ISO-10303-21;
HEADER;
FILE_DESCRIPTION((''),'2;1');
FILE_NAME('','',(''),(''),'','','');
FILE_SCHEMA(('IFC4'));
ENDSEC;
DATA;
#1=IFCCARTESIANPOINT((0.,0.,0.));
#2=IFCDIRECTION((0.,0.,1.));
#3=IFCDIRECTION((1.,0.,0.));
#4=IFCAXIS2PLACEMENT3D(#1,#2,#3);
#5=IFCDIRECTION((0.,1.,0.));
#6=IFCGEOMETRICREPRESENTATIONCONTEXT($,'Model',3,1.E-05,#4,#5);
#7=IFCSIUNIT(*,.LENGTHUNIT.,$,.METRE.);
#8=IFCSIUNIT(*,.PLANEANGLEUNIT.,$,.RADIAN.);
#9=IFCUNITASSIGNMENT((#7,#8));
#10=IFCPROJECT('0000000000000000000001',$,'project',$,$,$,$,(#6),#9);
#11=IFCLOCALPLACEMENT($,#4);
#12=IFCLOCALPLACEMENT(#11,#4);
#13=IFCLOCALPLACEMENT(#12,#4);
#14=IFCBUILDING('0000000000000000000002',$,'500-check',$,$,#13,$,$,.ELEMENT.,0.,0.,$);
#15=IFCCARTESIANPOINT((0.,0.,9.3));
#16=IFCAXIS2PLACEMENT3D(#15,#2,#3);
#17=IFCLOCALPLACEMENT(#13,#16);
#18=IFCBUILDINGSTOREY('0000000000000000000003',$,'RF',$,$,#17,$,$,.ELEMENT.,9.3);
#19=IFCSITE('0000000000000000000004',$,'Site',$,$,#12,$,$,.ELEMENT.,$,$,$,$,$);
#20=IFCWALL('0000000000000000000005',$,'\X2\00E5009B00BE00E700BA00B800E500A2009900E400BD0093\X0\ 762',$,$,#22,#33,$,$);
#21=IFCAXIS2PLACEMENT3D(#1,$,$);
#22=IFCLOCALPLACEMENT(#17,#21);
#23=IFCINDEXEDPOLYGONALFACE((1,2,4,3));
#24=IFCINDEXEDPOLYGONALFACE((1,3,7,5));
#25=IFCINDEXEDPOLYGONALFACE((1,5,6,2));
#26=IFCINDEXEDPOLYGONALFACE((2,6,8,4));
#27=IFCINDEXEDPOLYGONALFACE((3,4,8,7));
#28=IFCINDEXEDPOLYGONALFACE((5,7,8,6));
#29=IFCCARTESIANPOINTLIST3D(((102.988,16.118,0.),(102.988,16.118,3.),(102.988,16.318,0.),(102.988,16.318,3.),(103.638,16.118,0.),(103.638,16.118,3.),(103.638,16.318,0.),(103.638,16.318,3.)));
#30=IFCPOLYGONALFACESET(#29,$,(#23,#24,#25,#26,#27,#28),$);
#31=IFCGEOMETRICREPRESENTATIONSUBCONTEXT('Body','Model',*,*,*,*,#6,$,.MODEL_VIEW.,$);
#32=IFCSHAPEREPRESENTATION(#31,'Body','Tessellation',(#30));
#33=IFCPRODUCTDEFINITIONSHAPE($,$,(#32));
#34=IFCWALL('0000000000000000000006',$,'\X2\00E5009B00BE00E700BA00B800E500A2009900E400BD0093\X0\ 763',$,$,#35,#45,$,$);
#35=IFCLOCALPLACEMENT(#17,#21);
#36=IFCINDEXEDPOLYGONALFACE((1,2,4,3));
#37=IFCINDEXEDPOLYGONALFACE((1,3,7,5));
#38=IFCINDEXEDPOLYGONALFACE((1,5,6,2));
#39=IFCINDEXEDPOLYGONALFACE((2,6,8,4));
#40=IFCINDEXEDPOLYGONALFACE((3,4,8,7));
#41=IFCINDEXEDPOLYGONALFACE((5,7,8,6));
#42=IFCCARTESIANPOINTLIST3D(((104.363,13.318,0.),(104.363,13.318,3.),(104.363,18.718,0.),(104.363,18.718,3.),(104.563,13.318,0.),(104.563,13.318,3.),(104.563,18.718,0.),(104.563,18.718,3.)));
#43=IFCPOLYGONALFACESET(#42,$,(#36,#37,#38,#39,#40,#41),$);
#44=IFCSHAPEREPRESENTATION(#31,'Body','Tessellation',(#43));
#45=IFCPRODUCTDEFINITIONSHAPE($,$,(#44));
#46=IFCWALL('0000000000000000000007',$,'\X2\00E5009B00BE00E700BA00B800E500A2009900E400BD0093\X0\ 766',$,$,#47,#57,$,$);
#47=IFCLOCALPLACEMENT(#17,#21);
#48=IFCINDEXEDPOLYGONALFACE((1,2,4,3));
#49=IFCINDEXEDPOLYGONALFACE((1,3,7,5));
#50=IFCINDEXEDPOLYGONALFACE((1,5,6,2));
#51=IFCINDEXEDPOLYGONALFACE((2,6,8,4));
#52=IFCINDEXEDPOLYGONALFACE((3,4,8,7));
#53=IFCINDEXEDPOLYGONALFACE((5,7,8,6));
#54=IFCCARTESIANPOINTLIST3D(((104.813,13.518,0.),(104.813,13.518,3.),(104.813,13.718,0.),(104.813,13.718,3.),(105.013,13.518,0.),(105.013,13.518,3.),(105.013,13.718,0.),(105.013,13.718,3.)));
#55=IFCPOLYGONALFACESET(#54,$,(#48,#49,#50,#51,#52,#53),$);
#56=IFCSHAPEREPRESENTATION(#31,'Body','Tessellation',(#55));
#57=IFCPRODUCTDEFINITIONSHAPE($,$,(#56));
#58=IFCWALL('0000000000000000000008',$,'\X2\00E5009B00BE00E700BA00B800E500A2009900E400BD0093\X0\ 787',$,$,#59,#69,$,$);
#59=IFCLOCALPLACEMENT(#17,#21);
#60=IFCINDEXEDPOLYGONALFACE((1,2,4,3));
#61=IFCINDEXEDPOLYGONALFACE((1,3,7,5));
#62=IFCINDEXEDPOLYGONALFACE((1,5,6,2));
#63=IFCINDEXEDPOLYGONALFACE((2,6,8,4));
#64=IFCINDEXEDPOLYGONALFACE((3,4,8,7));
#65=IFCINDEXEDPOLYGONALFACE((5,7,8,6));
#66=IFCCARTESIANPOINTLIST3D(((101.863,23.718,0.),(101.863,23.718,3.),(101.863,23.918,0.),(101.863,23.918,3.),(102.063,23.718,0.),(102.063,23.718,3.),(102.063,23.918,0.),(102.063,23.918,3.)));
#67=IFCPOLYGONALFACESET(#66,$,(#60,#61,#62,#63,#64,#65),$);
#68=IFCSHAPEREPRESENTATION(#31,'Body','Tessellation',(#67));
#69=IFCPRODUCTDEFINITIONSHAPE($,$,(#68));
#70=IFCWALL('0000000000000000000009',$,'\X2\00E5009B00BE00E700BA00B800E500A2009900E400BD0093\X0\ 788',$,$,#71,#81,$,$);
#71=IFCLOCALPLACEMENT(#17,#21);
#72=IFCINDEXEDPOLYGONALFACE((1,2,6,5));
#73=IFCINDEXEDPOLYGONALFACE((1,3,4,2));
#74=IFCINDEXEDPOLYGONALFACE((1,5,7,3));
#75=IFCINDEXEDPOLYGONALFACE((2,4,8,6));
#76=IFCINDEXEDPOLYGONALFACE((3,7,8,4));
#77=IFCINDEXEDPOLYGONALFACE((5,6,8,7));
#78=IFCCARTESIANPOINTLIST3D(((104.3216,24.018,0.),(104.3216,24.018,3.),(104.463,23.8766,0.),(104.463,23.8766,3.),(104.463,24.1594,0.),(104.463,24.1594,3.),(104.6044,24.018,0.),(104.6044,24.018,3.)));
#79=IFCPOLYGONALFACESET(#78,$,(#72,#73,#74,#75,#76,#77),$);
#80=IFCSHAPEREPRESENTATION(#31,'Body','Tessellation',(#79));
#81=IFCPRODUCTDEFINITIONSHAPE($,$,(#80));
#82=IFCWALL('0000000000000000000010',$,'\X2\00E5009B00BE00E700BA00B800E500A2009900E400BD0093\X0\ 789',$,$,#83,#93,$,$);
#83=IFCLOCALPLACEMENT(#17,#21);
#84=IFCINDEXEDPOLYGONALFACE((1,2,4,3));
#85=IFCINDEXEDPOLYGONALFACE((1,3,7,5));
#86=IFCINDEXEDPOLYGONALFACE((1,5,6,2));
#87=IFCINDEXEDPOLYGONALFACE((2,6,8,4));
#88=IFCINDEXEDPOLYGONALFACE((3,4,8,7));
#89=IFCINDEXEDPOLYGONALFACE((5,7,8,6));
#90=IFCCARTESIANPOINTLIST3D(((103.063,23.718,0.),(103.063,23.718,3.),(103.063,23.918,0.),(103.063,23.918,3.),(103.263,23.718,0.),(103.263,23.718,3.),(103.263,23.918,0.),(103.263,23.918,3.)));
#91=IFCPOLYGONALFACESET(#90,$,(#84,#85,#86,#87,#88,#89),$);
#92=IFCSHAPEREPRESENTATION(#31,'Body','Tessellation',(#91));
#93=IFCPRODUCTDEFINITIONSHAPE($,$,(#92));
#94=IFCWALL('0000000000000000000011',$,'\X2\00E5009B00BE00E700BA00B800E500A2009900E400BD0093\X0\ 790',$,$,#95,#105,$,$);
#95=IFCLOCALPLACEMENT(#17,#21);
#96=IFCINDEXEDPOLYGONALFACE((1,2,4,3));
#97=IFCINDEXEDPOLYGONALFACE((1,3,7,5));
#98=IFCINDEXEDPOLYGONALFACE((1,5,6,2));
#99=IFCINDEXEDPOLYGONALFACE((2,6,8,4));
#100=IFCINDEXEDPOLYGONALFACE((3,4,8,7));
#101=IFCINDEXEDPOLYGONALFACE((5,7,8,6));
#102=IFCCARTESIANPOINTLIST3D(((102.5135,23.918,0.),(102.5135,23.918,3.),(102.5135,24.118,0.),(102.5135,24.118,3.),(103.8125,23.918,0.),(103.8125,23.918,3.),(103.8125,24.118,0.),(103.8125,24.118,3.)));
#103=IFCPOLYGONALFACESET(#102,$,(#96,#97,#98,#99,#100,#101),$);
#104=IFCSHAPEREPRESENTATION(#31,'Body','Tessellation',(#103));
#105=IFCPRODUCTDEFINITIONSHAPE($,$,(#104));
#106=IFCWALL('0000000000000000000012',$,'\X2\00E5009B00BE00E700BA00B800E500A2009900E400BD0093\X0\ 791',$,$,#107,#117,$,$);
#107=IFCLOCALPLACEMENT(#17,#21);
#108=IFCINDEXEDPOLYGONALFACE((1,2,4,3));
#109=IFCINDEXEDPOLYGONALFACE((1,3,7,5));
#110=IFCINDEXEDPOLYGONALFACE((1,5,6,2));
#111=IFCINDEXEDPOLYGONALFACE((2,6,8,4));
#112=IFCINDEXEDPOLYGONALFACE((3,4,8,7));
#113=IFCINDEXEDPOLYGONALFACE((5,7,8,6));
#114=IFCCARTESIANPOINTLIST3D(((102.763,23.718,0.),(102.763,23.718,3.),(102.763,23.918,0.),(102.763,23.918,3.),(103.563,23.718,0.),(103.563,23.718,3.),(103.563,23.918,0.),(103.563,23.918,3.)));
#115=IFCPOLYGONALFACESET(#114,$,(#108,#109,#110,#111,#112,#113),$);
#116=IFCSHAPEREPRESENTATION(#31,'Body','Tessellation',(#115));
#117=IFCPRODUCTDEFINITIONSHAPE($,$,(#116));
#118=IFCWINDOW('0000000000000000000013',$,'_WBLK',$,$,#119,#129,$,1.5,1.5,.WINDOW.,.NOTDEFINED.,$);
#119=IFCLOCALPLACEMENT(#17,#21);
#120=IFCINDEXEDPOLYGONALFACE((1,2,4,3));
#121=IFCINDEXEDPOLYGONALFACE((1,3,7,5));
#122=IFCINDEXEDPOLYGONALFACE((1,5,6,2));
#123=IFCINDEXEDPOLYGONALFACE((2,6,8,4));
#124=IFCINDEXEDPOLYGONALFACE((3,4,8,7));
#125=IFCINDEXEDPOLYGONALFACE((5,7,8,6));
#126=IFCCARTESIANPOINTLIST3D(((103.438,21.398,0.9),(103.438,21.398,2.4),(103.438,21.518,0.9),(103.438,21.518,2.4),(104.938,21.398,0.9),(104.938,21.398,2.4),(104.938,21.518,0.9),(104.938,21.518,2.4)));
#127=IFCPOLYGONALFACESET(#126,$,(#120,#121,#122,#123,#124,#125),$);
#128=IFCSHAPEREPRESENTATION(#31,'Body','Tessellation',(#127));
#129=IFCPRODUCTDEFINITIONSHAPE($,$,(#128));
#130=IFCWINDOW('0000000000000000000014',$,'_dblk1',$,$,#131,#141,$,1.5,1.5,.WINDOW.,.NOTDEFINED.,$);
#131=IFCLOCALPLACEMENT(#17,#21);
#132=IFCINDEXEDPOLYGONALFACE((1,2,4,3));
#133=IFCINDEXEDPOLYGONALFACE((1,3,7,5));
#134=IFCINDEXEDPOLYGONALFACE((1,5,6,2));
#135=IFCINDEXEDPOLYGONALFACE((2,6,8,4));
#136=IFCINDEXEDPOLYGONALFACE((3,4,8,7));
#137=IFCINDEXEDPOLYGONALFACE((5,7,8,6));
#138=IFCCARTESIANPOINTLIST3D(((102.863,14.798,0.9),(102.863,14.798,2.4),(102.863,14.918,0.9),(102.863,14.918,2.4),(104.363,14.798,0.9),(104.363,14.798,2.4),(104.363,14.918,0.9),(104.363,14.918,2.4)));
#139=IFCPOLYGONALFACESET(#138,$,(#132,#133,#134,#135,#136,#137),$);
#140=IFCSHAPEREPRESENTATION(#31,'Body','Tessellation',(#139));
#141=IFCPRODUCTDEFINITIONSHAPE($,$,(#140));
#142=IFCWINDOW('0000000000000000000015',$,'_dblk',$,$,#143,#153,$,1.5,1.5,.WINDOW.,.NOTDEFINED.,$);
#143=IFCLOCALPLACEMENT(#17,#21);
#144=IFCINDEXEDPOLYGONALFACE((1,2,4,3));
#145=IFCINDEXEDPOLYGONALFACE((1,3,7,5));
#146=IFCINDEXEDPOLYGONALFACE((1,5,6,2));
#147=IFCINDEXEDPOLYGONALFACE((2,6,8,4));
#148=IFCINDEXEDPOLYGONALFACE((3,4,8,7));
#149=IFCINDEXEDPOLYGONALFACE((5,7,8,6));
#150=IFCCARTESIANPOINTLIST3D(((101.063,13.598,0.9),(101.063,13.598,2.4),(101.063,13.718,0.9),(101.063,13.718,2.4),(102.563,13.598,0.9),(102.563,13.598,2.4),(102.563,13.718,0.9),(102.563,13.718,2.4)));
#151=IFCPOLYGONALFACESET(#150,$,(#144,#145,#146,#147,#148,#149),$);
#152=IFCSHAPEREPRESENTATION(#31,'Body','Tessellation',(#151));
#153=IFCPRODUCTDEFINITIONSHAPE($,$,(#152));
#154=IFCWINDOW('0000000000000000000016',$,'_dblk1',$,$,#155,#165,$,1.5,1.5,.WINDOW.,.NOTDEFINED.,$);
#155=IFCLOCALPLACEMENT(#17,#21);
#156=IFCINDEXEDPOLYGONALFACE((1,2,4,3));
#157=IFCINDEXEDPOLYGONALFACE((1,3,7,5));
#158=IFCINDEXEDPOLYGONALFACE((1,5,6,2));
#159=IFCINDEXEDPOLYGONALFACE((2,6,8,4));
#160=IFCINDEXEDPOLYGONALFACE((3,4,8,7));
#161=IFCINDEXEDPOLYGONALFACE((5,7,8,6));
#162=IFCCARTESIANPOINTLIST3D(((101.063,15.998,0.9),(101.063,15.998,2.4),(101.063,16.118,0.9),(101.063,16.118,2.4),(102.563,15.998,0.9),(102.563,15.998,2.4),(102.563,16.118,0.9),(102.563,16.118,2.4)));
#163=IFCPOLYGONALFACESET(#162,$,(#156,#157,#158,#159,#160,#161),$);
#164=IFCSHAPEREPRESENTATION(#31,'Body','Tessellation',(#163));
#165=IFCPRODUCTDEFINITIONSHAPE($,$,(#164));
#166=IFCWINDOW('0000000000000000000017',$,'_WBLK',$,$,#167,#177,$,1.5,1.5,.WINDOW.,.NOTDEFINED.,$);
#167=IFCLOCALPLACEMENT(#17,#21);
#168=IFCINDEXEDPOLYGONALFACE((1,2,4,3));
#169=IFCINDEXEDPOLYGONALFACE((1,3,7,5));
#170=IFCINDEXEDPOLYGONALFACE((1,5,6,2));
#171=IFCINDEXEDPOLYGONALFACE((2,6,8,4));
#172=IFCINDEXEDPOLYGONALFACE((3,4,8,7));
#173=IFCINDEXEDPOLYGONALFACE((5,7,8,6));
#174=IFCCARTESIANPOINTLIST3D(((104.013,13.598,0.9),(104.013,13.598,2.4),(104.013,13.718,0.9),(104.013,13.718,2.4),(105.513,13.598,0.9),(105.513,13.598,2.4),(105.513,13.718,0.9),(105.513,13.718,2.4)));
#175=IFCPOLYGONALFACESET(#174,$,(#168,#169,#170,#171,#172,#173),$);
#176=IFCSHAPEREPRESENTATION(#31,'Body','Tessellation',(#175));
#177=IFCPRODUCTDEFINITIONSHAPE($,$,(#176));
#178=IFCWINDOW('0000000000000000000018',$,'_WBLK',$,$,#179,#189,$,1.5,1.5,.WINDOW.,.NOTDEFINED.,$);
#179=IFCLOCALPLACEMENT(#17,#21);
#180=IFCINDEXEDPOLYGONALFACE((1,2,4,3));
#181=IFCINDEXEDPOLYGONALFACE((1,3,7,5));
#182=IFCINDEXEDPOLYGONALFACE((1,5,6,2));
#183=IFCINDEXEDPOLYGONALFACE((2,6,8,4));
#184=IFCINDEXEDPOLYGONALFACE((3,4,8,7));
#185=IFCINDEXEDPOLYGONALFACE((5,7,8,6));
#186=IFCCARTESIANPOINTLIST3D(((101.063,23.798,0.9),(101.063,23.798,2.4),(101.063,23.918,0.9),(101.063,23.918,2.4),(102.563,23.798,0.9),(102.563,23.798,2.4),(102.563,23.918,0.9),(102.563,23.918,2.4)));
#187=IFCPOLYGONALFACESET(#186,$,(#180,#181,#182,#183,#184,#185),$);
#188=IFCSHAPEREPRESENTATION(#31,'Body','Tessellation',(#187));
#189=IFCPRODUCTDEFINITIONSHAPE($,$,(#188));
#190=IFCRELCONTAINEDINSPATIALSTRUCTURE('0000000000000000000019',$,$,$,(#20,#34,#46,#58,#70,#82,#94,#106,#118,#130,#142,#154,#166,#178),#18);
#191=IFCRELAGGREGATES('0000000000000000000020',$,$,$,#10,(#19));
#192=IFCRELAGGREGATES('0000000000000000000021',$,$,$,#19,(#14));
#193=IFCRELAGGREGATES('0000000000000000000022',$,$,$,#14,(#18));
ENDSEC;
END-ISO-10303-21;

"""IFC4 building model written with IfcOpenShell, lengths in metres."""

from ifc_helpers import new_model, si_unit, direction, frame, frame_2d, origin_with_axes, place, context, subcontext, project, spatial, rectangle, extrude, element, save


model = new_model("IFC4")

# Units and contexts
model_context = context("Model", 3, precision=1e-05, world=origin_with_axes(), true_north=direction((0.0, 1.0, 0.0)))
body_context = subcontext(model_context, "Body", "Model", "MODEL_VIEW")
ifc_project = project(units=[si_unit("LENGTHUNIT", "METRE"), si_unit("PLANEANGLEUNIT", "RADIAN")], contexts=[model_context])

# Site, building, storey
placement = place(None, origin_with_axes())
site_placement = place(placement, origin_with_axes())
site = spatial("IfcSite", under=ifc_project, at=site_placement, Name="Site", CompositionType="ELEMENT")
building_placement = place(site_placement, origin_with_axes())
building = spatial("IfcBuilding", under=site, at=building_placement, Name="500-check", CompositionType="ELEMENT", ElevationOfRefHeight=0.0, ElevationOfTerrain=0.0)
storey_placement = place(building_placement, frame((0.0, 0.0, 9.3), z_axis=(0.0, 0.0, 1.0), x_axis=(1.0, 0.0, 0.0)))
storey = spatial("IfcBuildingStorey", under=building, at=storey_placement, Name="RF", CompositionType="ELEMENT", Elevation=9.3)

# Walls
wall_1_placement = place(storey_placement, frame((103.313, 16.218, 0.0), z_axis=(0.0, 0.0, 1.0), x_axis=(1.0, 0.0, 0.0)))
element("IfcWall", 1, at=wall_1_placement, inside=storey, Name="å\u009b¾çº¸å¢\u0099ä½\u0093 762", context=body_context, shape_type="SweptSolid", body=[
    extrude(rectangle(XDim=0.65, YDim=0.2, at=frame_2d((0.0, 0.0), x_axis=(1.0, 0.0, 0.0))), frame((0.0, 0.0, 0.0), z_axis=(0.0, 0.0, 1.0)), (0.0, 0.0, 1.0), 3.0),
])
wall_2_placement = place(storey_placement, frame((104.463, 16.018, 0.0), z_axis=(0.0, 0.0, 1.0), x_axis=(0.0, 1.0, 0.0)))
element("IfcWall", 2, at=wall_2_placement, inside=storey, Name="å\u009b¾çº¸å¢\u0099ä½\u0093 763", context=body_context, shape_type="SweptSolid", body=[
    extrude(rectangle(XDim=5.4, YDim=0.2, at=frame_2d((0.0, 0.0), x_axis=(1.0, 0.0, 0.0))), frame((0.0, 0.0, 0.0), z_axis=(0.0, 0.0, 1.0)), (0.0, 0.0, 1.0), 3.0),
])
for number, where, z_axis, x_axis, name in (
    (3, (104.913, 13.618, 0.0), (0.0, 0.0, 1.0), (0.0, 1.0, 0.0), "å\u009b¾çº¸å¢\u0099ä½\u0093 766"),
    (4, (101.963, 23.818, 0.0), (0.0, 0.0, 1.0), (0.0, 1.0, 0.0), "å\u009b¾çº¸å¢\u0099ä½\u0093 787"),
    (5, (104.463, 24.018, 0.0), (0.0, 0.0, 1.0), (0.707107, -0.707107, 0.0), "å\u009b¾çº¸å¢\u0099ä½\u0093 788"),
    (6, (103.163, 23.818, 0.0), (0.0, 0.0, 1.0), (0.0, 1.0, 0.0), "å\u009b¾çº¸å¢\u0099ä½\u0093 789"),
):
    element("IfcWall", number, at=place(storey_placement, frame(where, z_axis=z_axis, x_axis=x_axis)), inside=storey, Name=name, context=body_context, shape_type="SweptSolid", body=[
        extrude(rectangle(XDim=0.2, YDim=0.2, at=frame_2d((0.0, 0.0), x_axis=(1.0, 0.0, 0.0))), frame((0.0, 0.0, 0.0), z_axis=(0.0, 0.0, 1.0)), (0.0, 0.0, 1.0), 3.0),
    ])
wall_3_placement = place(storey_placement, frame((103.163, 24.018, 0.0), z_axis=(0.0, 0.0, 1.0), x_axis=(1.0, 0.0, 0.0)))
element("IfcWall", 7, at=wall_3_placement, inside=storey, Name="å\u009b¾çº¸å¢\u0099ä½\u0093 790", context=body_context, shape_type="SweptSolid", body=[
    extrude(rectangle(XDim=1.299, YDim=0.2, at=frame_2d((0.0, 0.0), x_axis=(1.0, 0.0, 0.0))), frame((0.0, 0.0, 0.0), z_axis=(0.0, 0.0, 1.0)), (0.0, 0.0, 1.0), 3.0),
])
wall_4_placement = place(storey_placement, frame((103.163, 23.818, 0.0), z_axis=(0.0, 0.0, 1.0), x_axis=(1.0, 0.0, 0.0)))
element("IfcWall", 8, at=wall_4_placement, inside=storey, Name="å\u009b¾çº¸å¢\u0099ä½\u0093 791", context=body_context, shape_type="SweptSolid", body=[
    extrude(rectangle(XDim=0.8, YDim=0.2, at=frame_2d((0.0, 0.0), x_axis=(1.0, 0.0, 0.0))), frame((0.0, 0.0, 0.0), z_axis=(0.0, 0.0, 1.0)), (0.0, 0.0, 1.0), 3.0),
])

# Windows
for number, where, z_axis, x_axis, name in (
    (9, (104.188, 21.458, 0.9), (0.0, 0.0, 1.0), (1.0, 0.0, 0.0), "_WBLK"),
    (10, (103.613, 14.858, 0.9), (0.0, 0.0, 1.0), (1.0, 0.0, 0.0), "_dblk1"),
    (11, (101.813, 13.658, 0.9), (0.0, 0.0, 1.0), (1.0, 0.0, 0.0), "_dblk"),
    (12, (101.813, 16.058, 0.9), (0.0, 0.0, 1.0), (1.0, 0.0, 0.0), "_dblk1"),
    (13, (104.763, 13.658, 0.9), (0.0, 0.0, 1.0), (1.0, 0.0, 0.0), "_WBLK"),
    (14, (101.813, 23.858, 0.9), (0.0, 0.0, 1.0), (1.0, 0.0, 0.0), "_WBLK"),
):
    element("IfcWindow", number, at=place(storey_placement, frame(where, z_axis=z_axis, x_axis=x_axis)), inside=storey, Name=name, OverallHeight=1.5, OverallWidth=1.5, PartitioningType="NOTDEFINED", PredefinedType="WINDOW", context=body_context, shape_type="SweptSolid", body=[
        extrude(rectangle(XDim=1.5, YDim=0.12, at=frame_2d((0.0, 0.0), x_axis=(1.0, 0.0, 0.0))), frame((0.0, 0.0, 0.0), z_axis=(0.0, 0.0, 1.0)), (0.0, 0.0, 1.0), 1.5),
    ])

save(model, "model.ifc")
